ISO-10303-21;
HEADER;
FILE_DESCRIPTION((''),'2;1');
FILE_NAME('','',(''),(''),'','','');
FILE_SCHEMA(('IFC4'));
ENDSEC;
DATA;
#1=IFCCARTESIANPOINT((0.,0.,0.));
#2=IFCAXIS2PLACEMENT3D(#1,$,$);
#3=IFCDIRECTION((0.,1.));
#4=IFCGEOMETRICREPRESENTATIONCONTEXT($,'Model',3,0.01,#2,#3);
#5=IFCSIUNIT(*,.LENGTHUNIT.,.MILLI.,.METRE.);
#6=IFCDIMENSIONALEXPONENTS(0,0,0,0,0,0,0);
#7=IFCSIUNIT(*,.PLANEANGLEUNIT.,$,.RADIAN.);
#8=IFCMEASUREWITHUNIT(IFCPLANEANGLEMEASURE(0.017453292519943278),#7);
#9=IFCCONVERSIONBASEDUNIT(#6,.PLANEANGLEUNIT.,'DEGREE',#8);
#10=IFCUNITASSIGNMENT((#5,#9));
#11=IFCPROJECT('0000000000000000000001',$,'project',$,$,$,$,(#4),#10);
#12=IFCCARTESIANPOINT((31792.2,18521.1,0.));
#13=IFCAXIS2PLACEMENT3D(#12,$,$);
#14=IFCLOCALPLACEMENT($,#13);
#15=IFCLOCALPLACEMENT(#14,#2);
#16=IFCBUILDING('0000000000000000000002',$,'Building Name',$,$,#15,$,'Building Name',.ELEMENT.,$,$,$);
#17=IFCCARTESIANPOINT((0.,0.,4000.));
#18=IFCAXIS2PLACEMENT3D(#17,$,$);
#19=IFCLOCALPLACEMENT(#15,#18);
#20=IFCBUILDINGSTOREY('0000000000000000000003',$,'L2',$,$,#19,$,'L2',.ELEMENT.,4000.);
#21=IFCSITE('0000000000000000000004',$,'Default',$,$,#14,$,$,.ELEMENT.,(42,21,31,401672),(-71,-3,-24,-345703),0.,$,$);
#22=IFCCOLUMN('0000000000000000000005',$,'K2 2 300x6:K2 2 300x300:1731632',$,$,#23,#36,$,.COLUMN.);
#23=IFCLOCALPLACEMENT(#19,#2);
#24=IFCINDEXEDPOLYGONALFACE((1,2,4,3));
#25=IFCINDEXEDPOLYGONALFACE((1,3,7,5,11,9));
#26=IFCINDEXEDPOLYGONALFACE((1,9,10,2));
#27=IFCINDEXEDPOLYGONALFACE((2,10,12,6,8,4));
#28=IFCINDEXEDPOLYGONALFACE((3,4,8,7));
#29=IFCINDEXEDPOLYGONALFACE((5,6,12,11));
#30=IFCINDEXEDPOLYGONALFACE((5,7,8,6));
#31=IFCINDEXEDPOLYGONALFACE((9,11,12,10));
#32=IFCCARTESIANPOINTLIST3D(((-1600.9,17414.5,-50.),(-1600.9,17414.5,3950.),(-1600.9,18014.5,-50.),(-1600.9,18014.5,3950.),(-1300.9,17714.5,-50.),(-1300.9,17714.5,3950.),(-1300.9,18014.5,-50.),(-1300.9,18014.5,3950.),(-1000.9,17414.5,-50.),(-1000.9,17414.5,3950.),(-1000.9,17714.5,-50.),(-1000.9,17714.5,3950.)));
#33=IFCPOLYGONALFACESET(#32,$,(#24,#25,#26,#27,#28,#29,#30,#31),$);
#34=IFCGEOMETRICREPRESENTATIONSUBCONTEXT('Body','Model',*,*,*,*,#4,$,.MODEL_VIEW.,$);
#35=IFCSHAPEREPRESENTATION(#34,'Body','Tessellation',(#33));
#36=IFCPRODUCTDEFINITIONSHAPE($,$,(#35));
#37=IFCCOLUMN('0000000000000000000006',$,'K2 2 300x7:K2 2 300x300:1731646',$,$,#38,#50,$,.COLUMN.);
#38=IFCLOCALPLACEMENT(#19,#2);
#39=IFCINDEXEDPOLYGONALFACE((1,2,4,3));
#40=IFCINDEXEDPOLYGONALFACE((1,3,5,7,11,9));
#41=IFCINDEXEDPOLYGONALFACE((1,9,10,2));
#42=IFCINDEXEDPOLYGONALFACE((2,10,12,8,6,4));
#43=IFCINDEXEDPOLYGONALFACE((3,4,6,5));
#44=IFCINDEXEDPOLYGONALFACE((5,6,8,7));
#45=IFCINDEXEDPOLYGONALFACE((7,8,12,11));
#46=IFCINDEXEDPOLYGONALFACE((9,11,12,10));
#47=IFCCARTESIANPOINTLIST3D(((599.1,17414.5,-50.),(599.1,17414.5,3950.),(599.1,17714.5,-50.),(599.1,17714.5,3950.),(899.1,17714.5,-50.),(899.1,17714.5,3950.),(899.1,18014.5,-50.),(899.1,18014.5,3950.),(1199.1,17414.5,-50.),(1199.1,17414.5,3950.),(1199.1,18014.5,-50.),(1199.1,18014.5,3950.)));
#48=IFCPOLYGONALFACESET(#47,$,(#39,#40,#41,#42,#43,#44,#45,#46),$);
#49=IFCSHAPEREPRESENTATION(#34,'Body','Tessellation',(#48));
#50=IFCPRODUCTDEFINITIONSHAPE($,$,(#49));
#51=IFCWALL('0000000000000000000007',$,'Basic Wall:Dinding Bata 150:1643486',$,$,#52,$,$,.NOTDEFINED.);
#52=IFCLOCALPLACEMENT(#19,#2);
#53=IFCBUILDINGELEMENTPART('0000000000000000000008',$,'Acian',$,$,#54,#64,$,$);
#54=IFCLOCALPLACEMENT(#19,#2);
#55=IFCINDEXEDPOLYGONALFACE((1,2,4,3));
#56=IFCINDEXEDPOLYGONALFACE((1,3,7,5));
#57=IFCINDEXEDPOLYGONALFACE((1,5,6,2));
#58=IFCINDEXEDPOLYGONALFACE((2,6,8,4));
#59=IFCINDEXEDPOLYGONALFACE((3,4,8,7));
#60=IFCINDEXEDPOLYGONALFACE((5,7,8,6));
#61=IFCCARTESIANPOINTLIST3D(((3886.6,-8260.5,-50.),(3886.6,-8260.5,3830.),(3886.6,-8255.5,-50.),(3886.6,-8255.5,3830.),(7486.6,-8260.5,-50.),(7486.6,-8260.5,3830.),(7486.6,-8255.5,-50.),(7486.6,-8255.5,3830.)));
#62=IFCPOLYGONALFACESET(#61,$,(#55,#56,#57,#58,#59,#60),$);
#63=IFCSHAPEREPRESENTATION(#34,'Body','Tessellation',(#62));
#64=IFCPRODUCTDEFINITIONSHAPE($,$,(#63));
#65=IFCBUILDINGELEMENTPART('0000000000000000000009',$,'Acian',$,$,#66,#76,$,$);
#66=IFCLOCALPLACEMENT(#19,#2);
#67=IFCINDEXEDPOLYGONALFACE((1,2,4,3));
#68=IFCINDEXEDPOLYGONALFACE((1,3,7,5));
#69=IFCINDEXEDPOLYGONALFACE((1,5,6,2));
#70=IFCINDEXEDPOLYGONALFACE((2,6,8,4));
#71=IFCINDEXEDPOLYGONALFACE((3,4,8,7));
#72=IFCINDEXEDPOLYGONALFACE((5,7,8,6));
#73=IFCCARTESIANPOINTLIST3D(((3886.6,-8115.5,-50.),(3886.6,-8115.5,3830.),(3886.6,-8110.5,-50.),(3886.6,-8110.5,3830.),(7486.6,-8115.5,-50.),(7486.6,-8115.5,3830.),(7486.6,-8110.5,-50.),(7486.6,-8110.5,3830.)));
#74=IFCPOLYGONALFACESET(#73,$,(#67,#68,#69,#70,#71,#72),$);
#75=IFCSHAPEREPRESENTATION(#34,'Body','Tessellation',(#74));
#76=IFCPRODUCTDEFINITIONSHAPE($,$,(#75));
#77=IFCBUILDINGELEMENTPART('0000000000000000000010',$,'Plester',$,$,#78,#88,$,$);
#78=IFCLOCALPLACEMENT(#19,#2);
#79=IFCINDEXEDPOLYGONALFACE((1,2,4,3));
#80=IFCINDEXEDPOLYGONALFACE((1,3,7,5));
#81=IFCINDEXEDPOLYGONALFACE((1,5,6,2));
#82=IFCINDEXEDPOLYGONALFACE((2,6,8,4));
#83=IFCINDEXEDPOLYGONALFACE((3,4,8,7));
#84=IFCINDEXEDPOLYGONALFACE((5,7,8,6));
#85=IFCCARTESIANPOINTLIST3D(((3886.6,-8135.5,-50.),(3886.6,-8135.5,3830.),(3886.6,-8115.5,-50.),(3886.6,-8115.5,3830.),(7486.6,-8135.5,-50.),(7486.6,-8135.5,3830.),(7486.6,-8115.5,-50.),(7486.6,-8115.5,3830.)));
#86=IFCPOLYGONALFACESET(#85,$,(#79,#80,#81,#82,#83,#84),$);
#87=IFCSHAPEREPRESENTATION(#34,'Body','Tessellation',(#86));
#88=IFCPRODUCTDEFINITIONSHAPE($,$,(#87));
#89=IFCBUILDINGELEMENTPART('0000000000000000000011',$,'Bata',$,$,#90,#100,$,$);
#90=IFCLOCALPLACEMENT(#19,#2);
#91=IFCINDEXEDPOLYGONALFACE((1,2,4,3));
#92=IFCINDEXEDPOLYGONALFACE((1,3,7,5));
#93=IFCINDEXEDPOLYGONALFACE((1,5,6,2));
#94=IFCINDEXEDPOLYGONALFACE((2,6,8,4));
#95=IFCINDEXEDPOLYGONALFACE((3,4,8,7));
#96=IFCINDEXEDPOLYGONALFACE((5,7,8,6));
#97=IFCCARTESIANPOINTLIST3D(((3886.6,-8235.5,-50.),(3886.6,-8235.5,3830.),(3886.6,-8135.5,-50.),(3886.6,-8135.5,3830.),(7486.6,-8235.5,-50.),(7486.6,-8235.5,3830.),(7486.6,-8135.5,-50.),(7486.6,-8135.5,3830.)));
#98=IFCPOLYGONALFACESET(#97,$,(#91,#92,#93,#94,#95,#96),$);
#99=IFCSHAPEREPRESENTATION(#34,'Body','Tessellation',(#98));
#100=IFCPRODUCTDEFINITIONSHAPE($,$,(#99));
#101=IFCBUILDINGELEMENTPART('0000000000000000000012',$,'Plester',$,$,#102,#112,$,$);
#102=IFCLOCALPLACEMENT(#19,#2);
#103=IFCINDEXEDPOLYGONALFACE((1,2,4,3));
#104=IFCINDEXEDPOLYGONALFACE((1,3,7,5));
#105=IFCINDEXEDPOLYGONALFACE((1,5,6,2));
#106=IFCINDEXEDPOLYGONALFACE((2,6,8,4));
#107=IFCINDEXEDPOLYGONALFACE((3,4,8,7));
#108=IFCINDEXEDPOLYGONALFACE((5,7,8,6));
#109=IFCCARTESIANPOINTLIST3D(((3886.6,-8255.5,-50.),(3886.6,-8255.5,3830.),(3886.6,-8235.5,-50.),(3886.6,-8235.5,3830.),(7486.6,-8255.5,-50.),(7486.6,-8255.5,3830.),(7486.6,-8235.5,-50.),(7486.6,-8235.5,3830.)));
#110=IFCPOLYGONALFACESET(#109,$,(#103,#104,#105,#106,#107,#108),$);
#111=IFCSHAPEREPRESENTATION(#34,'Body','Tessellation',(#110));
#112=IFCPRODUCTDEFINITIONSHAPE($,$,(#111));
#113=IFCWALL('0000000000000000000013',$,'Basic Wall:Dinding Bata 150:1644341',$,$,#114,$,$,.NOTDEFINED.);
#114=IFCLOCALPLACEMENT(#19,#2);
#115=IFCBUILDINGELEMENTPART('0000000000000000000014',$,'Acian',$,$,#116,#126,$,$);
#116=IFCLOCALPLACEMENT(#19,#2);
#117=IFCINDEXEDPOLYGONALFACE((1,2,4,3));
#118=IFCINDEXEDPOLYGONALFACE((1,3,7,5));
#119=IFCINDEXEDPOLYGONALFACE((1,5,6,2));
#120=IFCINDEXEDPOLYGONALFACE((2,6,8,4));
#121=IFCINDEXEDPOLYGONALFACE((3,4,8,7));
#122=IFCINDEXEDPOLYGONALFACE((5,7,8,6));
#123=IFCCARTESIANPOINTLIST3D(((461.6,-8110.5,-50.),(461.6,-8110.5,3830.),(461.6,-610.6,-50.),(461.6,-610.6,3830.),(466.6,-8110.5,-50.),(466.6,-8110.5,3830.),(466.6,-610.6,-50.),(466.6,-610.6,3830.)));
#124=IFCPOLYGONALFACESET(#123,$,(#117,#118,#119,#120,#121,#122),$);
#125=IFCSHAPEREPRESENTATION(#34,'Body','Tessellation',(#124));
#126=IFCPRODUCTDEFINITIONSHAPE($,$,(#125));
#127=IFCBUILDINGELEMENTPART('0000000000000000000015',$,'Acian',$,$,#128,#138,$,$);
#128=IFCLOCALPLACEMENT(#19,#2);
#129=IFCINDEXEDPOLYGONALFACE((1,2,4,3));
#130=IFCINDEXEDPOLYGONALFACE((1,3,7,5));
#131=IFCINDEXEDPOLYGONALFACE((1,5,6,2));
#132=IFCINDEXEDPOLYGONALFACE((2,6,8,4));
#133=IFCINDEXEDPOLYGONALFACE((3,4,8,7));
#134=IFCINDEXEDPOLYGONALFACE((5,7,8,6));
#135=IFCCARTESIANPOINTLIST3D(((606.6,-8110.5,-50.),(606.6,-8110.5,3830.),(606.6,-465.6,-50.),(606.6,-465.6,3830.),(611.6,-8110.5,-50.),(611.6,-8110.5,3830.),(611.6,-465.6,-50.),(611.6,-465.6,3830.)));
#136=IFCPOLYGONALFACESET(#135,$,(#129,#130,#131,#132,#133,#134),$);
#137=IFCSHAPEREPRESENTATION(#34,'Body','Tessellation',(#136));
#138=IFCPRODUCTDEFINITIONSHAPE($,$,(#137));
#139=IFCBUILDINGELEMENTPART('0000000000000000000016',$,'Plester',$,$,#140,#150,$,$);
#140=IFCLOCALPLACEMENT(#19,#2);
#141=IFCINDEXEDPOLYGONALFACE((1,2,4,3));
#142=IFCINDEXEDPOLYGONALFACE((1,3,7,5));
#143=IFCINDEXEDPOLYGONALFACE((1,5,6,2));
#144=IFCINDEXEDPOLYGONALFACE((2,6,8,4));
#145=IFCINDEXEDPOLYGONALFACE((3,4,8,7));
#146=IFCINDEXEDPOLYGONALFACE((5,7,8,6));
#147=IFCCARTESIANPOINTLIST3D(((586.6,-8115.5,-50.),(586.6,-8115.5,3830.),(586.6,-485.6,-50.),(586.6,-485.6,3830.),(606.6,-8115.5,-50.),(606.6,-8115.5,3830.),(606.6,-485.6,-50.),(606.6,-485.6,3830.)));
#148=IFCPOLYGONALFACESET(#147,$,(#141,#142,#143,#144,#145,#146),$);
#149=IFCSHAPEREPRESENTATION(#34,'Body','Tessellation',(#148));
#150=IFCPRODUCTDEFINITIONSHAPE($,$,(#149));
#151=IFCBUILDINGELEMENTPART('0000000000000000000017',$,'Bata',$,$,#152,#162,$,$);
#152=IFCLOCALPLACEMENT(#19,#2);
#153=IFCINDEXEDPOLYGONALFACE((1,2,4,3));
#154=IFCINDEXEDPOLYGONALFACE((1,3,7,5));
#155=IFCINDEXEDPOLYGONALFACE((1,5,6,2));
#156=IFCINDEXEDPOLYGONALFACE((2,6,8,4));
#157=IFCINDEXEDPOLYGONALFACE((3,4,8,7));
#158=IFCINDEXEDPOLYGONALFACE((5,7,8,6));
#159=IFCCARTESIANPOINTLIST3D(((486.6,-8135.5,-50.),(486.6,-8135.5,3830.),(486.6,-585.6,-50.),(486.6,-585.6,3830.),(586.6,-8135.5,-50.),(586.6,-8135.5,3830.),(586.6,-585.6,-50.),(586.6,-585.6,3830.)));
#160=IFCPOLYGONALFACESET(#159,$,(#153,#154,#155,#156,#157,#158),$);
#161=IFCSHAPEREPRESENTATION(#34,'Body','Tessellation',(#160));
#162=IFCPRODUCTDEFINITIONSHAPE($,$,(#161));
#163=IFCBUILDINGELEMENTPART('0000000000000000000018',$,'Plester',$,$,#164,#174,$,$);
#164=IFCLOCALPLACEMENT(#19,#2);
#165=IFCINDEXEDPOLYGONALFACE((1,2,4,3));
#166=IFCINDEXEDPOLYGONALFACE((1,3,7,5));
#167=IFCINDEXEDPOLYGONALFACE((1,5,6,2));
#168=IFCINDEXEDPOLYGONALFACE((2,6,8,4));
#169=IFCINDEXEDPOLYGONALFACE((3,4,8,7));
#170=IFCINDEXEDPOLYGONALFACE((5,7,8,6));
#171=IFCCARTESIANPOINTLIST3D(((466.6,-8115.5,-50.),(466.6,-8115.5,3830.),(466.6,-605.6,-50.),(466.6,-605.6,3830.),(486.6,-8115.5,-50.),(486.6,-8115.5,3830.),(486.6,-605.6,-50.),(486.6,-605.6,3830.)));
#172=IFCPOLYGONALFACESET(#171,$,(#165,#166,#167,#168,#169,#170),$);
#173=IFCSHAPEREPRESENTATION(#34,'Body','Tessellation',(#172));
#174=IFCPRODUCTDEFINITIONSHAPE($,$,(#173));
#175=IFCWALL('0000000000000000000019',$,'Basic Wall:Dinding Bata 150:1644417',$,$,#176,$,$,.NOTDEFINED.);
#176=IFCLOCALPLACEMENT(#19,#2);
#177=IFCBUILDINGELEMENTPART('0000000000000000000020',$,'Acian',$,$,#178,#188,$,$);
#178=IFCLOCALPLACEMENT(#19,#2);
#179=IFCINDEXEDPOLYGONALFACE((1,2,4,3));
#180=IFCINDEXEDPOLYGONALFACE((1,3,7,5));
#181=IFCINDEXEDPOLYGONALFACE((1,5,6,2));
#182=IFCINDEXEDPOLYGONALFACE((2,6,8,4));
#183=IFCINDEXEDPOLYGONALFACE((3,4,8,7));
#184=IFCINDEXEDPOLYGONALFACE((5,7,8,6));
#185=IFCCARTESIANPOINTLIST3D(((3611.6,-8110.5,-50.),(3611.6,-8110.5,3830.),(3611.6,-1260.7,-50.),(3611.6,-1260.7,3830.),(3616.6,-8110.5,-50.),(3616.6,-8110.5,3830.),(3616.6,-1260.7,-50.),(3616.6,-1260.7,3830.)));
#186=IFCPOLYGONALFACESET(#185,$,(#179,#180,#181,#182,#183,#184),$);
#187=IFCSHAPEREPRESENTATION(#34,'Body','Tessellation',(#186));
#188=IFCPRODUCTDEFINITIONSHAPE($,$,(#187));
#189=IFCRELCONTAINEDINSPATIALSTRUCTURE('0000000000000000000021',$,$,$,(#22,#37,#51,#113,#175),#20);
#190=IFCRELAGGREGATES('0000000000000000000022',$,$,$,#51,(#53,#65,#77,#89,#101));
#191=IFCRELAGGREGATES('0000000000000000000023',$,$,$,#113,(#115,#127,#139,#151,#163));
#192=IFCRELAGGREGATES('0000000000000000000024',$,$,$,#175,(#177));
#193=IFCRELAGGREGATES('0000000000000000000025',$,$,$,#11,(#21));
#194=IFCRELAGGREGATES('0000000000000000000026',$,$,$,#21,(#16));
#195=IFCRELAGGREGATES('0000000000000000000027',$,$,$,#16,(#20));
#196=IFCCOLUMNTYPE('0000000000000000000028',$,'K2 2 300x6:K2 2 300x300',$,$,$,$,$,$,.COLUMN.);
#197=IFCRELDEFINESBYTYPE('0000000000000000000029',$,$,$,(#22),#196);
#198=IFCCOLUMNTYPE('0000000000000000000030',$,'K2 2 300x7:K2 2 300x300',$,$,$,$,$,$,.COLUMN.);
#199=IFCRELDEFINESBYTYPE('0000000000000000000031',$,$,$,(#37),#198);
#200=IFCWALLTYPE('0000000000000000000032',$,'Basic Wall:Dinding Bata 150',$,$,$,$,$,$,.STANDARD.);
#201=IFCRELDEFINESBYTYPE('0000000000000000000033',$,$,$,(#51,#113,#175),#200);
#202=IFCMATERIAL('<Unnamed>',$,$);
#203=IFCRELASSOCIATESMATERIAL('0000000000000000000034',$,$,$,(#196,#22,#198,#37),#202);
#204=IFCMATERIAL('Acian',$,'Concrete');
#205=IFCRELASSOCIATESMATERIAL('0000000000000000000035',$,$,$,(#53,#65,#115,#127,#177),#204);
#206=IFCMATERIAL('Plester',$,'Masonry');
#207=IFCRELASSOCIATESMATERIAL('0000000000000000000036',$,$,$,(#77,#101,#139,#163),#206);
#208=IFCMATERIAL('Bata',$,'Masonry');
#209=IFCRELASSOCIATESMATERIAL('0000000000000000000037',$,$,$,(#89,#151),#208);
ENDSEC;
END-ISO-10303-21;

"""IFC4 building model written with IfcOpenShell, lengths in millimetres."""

from ifc_helpers import new_model, entity, si_unit, converted_unit, direction, frame, origin, place, context, subcontext, project, spatial, indexed_curve, outline, extrude, source, transform, mapped, material, type_object, type_shapes, element, aggregate, save


model = new_model("IFC4")

# Units and contexts
model_context = context("Model", 3, precision=0.01, world=origin(), true_north=direction((0.0, 1.0)))
body_context = subcontext(model_context, "Body", "Model", "MODEL_VIEW")
ifc_project = project(units=[si_unit("LENGTHUNIT", "METRE", prefix="MILLI"), converted_unit("PLANEANGLEUNIT", "DEGREE", entity("IfcPlaneAngleMeasure", 0.017453292519943278), si_unit("PLANEANGLEUNIT", "RADIAN"), dimensions=[0, 0, 0, 0, 0, 0, 0])], contexts=[model_context])

# Site, building, storey
site_placement = place(None, frame((31792.2, 18521.1, 0.0)))
site = spatial("IfcSite", under=ifc_project, at=site_placement, Name="Default", CompositionType="ELEMENT", RefLatitude=(42, 21, 31, 401672), RefLongitude=(-71, -3, -24, -345703), RefElevation=0.0)
building_placement = place(site_placement, origin())
building = spatial("IfcBuilding", under=site, at=building_placement, Name="Building Name", LongName="Building Name", CompositionType="ELEMENT")
storey_placement = place(building_placement, frame((0.0, 0.0, 4000.0)))
storey = spatial("IfcBuildingStorey", under=building, at=storey_placement, Name="L2", LongName="L2", CompositionType="ELEMENT", Elevation=4000.0)

# Columns
ifc_material_1 = material(Name="<Unnamed>")
column_type_1 = type_object("IfcColumnType", Name="K2 2 300x6:K2 2 300x300", PredefinedType="COLUMN", material=ifc_material_1)
shared_shape_1 = source(origin(), body_context, "Body", "SweptSolid", [
    extrude(outline(indexed_curve([(-300.0, 0.0), (-300.0, -300.0), (300.0, -300.0), (300.0, 300.0), (0.0, 300.0), (0.0, 0.0), (-300.0, 0.0)], self_intersect=False)), frame((-1300.9, 18969.5, 3950.0), z_axis=(0.0, 0.0, -1.0), x_axis=(-1.0, 0.0, 0.0)), (0.0, 0.0, -1.0), 4000.0),
])
type_shapes(column_type_1, [shared_shape_1])
column_1_placement = place(storey_placement, frame((0.0, -1255.0, -4000.0)))
element("IfcColumn", 1, at=column_1_placement, inside=storey, type_object=column_type_1, material=ifc_material_1, Name="K2 2 300x6:K2 2 300x300:1731632", PredefinedType="COLUMN", context=body_context, shape_type="MappedRepresentation", body=[
    mapped(shared_shape_1, transform((0.0, 0.0, 0.0), scale=1.0)),
])
column_type_2 = type_object("IfcColumnType", Name="K2 2 300x7:K2 2 300x300", PredefinedType="COLUMN", material=ifc_material_1)
shared_shape_2 = source(origin(), body_context, "Body", "SweptSolid", [
    extrude(outline(indexed_curve([(0.0, -300.0), (300.0, -300.0), (300.0, 300.0), (-300.0, 300.0), (-300.0, 0.0), (0.0, 0.0), (0.0, -300.0)], self_intersect=False)), frame((674.1, 18969.5, 3950.0), z_axis=(0.0, 0.0, 1.0), x_axis=(0.0, -1.0, 0.0)), (0.0, 0.0, 1.0), 4000.0),
])
type_shapes(column_type_2, [shared_shape_2])
column_2_placement = place(storey_placement, frame((225.0, -1255.0, -4000.0)))
element("IfcColumn", 2, at=column_2_placement, inside=storey, type_object=column_type_2, material=ifc_material_1, Name="K2 2 300x7:K2 2 300x300:1731646", PredefinedType="COLUMN", context=body_context, shape_type="MappedRepresentation", body=[
    mapped(shared_shape_2, transform((0.0, 0.0, 0.0), scale=1.0)),
])

# Walls, building element parts
wall_type_1 = type_object("IfcWallType", Name="Basic Wall:Dinding Bata 150", PredefinedType="STANDARD")
wall_1_placement = place(storey_placement, frame((3886.6, -8185.5, -50.0)))
wall_1 = element("IfcWall", 3, at=wall_1_placement, inside=storey, type_object=wall_type_1, Name="Basic Wall:Dinding Bata 150:1643486", PredefinedType="NOTDEFINED")
ifc_material_2 = material(Name="Acian", Category="Concrete")
building_element_part_1_placement = place(wall_1_placement, origin())
building_element_part_1 = element("IfcBuildingElementPart", 4, at=building_element_part_1_placement, material=ifc_material_2, Name="Acian", context=body_context, shape_type="SweptSolid", body=[
    extrude(outline(indexed_curve([(-2.5, -1800.0), (2.5, -1800.0), (2.5, 1800.0), (-2.5, 1800.0), (-2.5, -1800.0)], self_intersect=False)), frame((1800.0, -72.5, 0.0), z_axis=(0.0, 0.0, 1.0), x_axis=(0.0, -1.0, 0.0)), (0.0, 0.0, 1.0), 3880.0),
])
building_element_part_2_placement = place(wall_1_placement, origin())
building_element_part_2 = element("IfcBuildingElementPart", 5, at=building_element_part_2_placement, material=ifc_material_2, Name="Acian", context=body_context, shape_type="SweptSolid", body=[
    extrude(outline(indexed_curve([(-2.5, -1800.0), (2.5, -1800.0), (2.5, 1800.0), (-2.5, 1800.0), (-2.5, -1800.0)], self_intersect=False)), frame((1800.0, 72.5, 0.0), z_axis=(0.0, 0.0, 1.0), x_axis=(0.0, -1.0, 0.0)), (0.0, 0.0, 1.0), 3880.0),
])
ifc_material_3 = material(Name="Plester", Category="Masonry")
building_element_part_3_placement = place(wall_1_placement, origin())
building_element_part_3 = element("IfcBuildingElementPart", 6, at=building_element_part_3_placement, material=ifc_material_3, Name="Plester", context=body_context, shape_type="SweptSolid", body=[
    extrude(outline(indexed_curve([(-10.0, -1800.0), (10.0, -1800.0), (10.0, 1800.0), (-10.0, 1800.0), (-10.0, -1800.0)], self_intersect=False)), frame((1800.0, 60.0, 0.0), z_axis=(0.0, 0.0, 1.0), x_axis=(0.0, -1.0, 0.0)), (0.0, 0.0, 1.0), 3880.0),
])
ifc_material_4 = material(Name="Bata", Category="Masonry")
building_element_part_4_placement = place(wall_1_placement, origin())
building_element_part_4 = element("IfcBuildingElementPart", 7, at=building_element_part_4_placement, material=ifc_material_4, Name="Bata", context=body_context, shape_type="SweptSolid", body=[
    extrude(outline(indexed_curve([(-50.0, -1800.0), (50.0, -1800.0), (50.0, 1800.0), (-50.0, 1800.0), (-50.0, -1800.0)], self_intersect=False)), frame((1800.0, 0.0, 0.0), z_axis=(0.0, 0.0, 1.0), x_axis=(0.0, -1.0, 0.0)), (0.0, 0.0, 1.0), 3880.0),
])
building_element_part_5_placement = place(wall_1_placement, origin())
building_element_part_5 = element("IfcBuildingElementPart", 8, at=building_element_part_5_placement, material=ifc_material_3, Name="Plester", context=body_context, shape_type="SweptSolid", body=[
    extrude(outline(indexed_curve([(-10.0, -1800.0), (10.0, -1800.0), (10.0, 1800.0), (-10.0, 1800.0), (-10.0, -1800.0)], self_intersect=False)), frame((1800.0, -60.0, 0.0), z_axis=(0.0, 0.0, 1.0), x_axis=(0.0, -1.0, 0.0)), (0.0, 0.0, 1.0), 3880.0),
])
aggregate(wall_1, [building_element_part_1, building_element_part_2, building_element_part_3, building_element_part_4, building_element_part_5])
wall_2_placement = place(storey_placement, frame((536.6, -610.6, -50.0), z_axis=(0.0, 0.0, 1.0), x_axis=(0.0, -1.0, 0.0)))
wall_2 = element("IfcWall", 9, at=wall_2_placement, inside=storey, type_object=wall_type_1, Name="Basic Wall:Dinding Bata 150:1644341", PredefinedType="NOTDEFINED")
building_element_part_6_placement = place(wall_2_placement, origin())
building_element_part_6 = element("IfcBuildingElementPart", 10, at=building_element_part_6_placement, material=ifc_material_2, Name="Acian", context=body_context, shape_type="SweptSolid", body=[
    extrude(outline(indexed_curve([(-3750.0, -2.5), (3750.0, -2.5), (3750.0, 2.5), (-3750.0, 2.5), (-3750.0, -2.5)], self_intersect=False)), frame((3750.0, -72.5, 0.0)), (0.0, 0.0, 1.0), 3880.0),
])
building_element_part_7_placement = place(wall_2_placement, origin())
building_element_part_7 = element("IfcBuildingElementPart", 11, at=building_element_part_7_placement, material=ifc_material_2, Name="Acian", context=body_context, shape_type="SweptSolid", body=[
    extrude(outline(indexed_curve([(-3822.5, -2.5), (3822.5, -2.5), (3822.5, 2.5), (-3822.5, 2.5), (-3822.5, -2.5)], self_intersect=False)), frame((3677.5, 72.5, 0.0)), (0.0, 0.0, 1.0), 3880.0),
])
building_element_part_8_placement = place(wall_2_placement, origin())
building_element_part_8 = element("IfcBuildingElementPart", 12, at=building_element_part_8_placement, material=ifc_material_3, Name="Plester", context=body_context, shape_type="SweptSolid", body=[
    extrude(outline(indexed_curve([(-3815.0, -10.0), (3815.0, -10.0), (3815.0, 10.0), (-3815.0, 10.0), (-3815.0, -10.0)], self_intersect=False)), frame((3690.0, 60.0, 0.0)), (0.0, 0.0, 1.0), 3880.0),
])
building_element_part_9_placement = place(wall_2_placement, origin())
building_element_part_9 = element("IfcBuildingElementPart", 13, at=building_element_part_9_placement, material=ifc_material_4, Name="Bata", context=body_context, shape_type="SweptSolid", body=[
    extrude(outline(indexed_curve([(-3775.0, -50.0), (3775.0, -50.0), (3775.0, 50.0), (-3775.0, 50.0), (-3775.0, -50.0)], self_intersect=False)), frame((3750.0, 0.0, 0.0)), (0.0, 0.0, 1.0), 3880.0),
])
building_element_part_10_placement = place(wall_2_placement, origin())
building_element_part_10 = element("IfcBuildingElementPart", 14, at=building_element_part_10_placement, material=ifc_material_3, Name="Plester", context=body_context, shape_type="SweptSolid", body=[
    extrude(outline(indexed_curve([(-3755.0, -10.0), (3755.0, -10.0), (3755.0, 10.0), (-3755.0, 10.0), (-3755.0, -10.0)], self_intersect=False)), frame((3750.0, -60.0, 0.0)), (0.0, 0.0, 1.0), 3880.0),
])
aggregate(wall_2, [building_element_part_6, building_element_part_7, building_element_part_8, building_element_part_9, building_element_part_10])
wall_3_placement = place(storey_placement, frame((3686.6, -1260.7, -50.0), z_axis=(0.0, 0.0, 1.0), x_axis=(0.0, -1.0, 0.0)))
wall_3 = element("IfcWall", 15, at=wall_3_placement, inside=storey, type_object=wall_type_1, Name="Basic Wall:Dinding Bata 150:1644417", PredefinedType="NOTDEFINED")
building_element_part_11_placement = place(wall_3_placement, origin())
building_element_part_11 = element("IfcBuildingElementPart", 16, at=building_element_part_11_placement, material=ifc_material_2, Name="Acian", context=body_context, shape_type="SweptSolid", body=[
    extrude(outline(indexed_curve([(-3424.9, -2.5), (3424.9, -2.5), (3424.9, 2.5), (-3424.9, 2.5), (-3424.9, -2.5)], self_intersect=False)), frame((3424.9, -72.5, 0.0)), (0.0, 0.0, 1.0), 3880.0),
])
aggregate(wall_3, [building_element_part_11])

save(model, "model.ifc")
